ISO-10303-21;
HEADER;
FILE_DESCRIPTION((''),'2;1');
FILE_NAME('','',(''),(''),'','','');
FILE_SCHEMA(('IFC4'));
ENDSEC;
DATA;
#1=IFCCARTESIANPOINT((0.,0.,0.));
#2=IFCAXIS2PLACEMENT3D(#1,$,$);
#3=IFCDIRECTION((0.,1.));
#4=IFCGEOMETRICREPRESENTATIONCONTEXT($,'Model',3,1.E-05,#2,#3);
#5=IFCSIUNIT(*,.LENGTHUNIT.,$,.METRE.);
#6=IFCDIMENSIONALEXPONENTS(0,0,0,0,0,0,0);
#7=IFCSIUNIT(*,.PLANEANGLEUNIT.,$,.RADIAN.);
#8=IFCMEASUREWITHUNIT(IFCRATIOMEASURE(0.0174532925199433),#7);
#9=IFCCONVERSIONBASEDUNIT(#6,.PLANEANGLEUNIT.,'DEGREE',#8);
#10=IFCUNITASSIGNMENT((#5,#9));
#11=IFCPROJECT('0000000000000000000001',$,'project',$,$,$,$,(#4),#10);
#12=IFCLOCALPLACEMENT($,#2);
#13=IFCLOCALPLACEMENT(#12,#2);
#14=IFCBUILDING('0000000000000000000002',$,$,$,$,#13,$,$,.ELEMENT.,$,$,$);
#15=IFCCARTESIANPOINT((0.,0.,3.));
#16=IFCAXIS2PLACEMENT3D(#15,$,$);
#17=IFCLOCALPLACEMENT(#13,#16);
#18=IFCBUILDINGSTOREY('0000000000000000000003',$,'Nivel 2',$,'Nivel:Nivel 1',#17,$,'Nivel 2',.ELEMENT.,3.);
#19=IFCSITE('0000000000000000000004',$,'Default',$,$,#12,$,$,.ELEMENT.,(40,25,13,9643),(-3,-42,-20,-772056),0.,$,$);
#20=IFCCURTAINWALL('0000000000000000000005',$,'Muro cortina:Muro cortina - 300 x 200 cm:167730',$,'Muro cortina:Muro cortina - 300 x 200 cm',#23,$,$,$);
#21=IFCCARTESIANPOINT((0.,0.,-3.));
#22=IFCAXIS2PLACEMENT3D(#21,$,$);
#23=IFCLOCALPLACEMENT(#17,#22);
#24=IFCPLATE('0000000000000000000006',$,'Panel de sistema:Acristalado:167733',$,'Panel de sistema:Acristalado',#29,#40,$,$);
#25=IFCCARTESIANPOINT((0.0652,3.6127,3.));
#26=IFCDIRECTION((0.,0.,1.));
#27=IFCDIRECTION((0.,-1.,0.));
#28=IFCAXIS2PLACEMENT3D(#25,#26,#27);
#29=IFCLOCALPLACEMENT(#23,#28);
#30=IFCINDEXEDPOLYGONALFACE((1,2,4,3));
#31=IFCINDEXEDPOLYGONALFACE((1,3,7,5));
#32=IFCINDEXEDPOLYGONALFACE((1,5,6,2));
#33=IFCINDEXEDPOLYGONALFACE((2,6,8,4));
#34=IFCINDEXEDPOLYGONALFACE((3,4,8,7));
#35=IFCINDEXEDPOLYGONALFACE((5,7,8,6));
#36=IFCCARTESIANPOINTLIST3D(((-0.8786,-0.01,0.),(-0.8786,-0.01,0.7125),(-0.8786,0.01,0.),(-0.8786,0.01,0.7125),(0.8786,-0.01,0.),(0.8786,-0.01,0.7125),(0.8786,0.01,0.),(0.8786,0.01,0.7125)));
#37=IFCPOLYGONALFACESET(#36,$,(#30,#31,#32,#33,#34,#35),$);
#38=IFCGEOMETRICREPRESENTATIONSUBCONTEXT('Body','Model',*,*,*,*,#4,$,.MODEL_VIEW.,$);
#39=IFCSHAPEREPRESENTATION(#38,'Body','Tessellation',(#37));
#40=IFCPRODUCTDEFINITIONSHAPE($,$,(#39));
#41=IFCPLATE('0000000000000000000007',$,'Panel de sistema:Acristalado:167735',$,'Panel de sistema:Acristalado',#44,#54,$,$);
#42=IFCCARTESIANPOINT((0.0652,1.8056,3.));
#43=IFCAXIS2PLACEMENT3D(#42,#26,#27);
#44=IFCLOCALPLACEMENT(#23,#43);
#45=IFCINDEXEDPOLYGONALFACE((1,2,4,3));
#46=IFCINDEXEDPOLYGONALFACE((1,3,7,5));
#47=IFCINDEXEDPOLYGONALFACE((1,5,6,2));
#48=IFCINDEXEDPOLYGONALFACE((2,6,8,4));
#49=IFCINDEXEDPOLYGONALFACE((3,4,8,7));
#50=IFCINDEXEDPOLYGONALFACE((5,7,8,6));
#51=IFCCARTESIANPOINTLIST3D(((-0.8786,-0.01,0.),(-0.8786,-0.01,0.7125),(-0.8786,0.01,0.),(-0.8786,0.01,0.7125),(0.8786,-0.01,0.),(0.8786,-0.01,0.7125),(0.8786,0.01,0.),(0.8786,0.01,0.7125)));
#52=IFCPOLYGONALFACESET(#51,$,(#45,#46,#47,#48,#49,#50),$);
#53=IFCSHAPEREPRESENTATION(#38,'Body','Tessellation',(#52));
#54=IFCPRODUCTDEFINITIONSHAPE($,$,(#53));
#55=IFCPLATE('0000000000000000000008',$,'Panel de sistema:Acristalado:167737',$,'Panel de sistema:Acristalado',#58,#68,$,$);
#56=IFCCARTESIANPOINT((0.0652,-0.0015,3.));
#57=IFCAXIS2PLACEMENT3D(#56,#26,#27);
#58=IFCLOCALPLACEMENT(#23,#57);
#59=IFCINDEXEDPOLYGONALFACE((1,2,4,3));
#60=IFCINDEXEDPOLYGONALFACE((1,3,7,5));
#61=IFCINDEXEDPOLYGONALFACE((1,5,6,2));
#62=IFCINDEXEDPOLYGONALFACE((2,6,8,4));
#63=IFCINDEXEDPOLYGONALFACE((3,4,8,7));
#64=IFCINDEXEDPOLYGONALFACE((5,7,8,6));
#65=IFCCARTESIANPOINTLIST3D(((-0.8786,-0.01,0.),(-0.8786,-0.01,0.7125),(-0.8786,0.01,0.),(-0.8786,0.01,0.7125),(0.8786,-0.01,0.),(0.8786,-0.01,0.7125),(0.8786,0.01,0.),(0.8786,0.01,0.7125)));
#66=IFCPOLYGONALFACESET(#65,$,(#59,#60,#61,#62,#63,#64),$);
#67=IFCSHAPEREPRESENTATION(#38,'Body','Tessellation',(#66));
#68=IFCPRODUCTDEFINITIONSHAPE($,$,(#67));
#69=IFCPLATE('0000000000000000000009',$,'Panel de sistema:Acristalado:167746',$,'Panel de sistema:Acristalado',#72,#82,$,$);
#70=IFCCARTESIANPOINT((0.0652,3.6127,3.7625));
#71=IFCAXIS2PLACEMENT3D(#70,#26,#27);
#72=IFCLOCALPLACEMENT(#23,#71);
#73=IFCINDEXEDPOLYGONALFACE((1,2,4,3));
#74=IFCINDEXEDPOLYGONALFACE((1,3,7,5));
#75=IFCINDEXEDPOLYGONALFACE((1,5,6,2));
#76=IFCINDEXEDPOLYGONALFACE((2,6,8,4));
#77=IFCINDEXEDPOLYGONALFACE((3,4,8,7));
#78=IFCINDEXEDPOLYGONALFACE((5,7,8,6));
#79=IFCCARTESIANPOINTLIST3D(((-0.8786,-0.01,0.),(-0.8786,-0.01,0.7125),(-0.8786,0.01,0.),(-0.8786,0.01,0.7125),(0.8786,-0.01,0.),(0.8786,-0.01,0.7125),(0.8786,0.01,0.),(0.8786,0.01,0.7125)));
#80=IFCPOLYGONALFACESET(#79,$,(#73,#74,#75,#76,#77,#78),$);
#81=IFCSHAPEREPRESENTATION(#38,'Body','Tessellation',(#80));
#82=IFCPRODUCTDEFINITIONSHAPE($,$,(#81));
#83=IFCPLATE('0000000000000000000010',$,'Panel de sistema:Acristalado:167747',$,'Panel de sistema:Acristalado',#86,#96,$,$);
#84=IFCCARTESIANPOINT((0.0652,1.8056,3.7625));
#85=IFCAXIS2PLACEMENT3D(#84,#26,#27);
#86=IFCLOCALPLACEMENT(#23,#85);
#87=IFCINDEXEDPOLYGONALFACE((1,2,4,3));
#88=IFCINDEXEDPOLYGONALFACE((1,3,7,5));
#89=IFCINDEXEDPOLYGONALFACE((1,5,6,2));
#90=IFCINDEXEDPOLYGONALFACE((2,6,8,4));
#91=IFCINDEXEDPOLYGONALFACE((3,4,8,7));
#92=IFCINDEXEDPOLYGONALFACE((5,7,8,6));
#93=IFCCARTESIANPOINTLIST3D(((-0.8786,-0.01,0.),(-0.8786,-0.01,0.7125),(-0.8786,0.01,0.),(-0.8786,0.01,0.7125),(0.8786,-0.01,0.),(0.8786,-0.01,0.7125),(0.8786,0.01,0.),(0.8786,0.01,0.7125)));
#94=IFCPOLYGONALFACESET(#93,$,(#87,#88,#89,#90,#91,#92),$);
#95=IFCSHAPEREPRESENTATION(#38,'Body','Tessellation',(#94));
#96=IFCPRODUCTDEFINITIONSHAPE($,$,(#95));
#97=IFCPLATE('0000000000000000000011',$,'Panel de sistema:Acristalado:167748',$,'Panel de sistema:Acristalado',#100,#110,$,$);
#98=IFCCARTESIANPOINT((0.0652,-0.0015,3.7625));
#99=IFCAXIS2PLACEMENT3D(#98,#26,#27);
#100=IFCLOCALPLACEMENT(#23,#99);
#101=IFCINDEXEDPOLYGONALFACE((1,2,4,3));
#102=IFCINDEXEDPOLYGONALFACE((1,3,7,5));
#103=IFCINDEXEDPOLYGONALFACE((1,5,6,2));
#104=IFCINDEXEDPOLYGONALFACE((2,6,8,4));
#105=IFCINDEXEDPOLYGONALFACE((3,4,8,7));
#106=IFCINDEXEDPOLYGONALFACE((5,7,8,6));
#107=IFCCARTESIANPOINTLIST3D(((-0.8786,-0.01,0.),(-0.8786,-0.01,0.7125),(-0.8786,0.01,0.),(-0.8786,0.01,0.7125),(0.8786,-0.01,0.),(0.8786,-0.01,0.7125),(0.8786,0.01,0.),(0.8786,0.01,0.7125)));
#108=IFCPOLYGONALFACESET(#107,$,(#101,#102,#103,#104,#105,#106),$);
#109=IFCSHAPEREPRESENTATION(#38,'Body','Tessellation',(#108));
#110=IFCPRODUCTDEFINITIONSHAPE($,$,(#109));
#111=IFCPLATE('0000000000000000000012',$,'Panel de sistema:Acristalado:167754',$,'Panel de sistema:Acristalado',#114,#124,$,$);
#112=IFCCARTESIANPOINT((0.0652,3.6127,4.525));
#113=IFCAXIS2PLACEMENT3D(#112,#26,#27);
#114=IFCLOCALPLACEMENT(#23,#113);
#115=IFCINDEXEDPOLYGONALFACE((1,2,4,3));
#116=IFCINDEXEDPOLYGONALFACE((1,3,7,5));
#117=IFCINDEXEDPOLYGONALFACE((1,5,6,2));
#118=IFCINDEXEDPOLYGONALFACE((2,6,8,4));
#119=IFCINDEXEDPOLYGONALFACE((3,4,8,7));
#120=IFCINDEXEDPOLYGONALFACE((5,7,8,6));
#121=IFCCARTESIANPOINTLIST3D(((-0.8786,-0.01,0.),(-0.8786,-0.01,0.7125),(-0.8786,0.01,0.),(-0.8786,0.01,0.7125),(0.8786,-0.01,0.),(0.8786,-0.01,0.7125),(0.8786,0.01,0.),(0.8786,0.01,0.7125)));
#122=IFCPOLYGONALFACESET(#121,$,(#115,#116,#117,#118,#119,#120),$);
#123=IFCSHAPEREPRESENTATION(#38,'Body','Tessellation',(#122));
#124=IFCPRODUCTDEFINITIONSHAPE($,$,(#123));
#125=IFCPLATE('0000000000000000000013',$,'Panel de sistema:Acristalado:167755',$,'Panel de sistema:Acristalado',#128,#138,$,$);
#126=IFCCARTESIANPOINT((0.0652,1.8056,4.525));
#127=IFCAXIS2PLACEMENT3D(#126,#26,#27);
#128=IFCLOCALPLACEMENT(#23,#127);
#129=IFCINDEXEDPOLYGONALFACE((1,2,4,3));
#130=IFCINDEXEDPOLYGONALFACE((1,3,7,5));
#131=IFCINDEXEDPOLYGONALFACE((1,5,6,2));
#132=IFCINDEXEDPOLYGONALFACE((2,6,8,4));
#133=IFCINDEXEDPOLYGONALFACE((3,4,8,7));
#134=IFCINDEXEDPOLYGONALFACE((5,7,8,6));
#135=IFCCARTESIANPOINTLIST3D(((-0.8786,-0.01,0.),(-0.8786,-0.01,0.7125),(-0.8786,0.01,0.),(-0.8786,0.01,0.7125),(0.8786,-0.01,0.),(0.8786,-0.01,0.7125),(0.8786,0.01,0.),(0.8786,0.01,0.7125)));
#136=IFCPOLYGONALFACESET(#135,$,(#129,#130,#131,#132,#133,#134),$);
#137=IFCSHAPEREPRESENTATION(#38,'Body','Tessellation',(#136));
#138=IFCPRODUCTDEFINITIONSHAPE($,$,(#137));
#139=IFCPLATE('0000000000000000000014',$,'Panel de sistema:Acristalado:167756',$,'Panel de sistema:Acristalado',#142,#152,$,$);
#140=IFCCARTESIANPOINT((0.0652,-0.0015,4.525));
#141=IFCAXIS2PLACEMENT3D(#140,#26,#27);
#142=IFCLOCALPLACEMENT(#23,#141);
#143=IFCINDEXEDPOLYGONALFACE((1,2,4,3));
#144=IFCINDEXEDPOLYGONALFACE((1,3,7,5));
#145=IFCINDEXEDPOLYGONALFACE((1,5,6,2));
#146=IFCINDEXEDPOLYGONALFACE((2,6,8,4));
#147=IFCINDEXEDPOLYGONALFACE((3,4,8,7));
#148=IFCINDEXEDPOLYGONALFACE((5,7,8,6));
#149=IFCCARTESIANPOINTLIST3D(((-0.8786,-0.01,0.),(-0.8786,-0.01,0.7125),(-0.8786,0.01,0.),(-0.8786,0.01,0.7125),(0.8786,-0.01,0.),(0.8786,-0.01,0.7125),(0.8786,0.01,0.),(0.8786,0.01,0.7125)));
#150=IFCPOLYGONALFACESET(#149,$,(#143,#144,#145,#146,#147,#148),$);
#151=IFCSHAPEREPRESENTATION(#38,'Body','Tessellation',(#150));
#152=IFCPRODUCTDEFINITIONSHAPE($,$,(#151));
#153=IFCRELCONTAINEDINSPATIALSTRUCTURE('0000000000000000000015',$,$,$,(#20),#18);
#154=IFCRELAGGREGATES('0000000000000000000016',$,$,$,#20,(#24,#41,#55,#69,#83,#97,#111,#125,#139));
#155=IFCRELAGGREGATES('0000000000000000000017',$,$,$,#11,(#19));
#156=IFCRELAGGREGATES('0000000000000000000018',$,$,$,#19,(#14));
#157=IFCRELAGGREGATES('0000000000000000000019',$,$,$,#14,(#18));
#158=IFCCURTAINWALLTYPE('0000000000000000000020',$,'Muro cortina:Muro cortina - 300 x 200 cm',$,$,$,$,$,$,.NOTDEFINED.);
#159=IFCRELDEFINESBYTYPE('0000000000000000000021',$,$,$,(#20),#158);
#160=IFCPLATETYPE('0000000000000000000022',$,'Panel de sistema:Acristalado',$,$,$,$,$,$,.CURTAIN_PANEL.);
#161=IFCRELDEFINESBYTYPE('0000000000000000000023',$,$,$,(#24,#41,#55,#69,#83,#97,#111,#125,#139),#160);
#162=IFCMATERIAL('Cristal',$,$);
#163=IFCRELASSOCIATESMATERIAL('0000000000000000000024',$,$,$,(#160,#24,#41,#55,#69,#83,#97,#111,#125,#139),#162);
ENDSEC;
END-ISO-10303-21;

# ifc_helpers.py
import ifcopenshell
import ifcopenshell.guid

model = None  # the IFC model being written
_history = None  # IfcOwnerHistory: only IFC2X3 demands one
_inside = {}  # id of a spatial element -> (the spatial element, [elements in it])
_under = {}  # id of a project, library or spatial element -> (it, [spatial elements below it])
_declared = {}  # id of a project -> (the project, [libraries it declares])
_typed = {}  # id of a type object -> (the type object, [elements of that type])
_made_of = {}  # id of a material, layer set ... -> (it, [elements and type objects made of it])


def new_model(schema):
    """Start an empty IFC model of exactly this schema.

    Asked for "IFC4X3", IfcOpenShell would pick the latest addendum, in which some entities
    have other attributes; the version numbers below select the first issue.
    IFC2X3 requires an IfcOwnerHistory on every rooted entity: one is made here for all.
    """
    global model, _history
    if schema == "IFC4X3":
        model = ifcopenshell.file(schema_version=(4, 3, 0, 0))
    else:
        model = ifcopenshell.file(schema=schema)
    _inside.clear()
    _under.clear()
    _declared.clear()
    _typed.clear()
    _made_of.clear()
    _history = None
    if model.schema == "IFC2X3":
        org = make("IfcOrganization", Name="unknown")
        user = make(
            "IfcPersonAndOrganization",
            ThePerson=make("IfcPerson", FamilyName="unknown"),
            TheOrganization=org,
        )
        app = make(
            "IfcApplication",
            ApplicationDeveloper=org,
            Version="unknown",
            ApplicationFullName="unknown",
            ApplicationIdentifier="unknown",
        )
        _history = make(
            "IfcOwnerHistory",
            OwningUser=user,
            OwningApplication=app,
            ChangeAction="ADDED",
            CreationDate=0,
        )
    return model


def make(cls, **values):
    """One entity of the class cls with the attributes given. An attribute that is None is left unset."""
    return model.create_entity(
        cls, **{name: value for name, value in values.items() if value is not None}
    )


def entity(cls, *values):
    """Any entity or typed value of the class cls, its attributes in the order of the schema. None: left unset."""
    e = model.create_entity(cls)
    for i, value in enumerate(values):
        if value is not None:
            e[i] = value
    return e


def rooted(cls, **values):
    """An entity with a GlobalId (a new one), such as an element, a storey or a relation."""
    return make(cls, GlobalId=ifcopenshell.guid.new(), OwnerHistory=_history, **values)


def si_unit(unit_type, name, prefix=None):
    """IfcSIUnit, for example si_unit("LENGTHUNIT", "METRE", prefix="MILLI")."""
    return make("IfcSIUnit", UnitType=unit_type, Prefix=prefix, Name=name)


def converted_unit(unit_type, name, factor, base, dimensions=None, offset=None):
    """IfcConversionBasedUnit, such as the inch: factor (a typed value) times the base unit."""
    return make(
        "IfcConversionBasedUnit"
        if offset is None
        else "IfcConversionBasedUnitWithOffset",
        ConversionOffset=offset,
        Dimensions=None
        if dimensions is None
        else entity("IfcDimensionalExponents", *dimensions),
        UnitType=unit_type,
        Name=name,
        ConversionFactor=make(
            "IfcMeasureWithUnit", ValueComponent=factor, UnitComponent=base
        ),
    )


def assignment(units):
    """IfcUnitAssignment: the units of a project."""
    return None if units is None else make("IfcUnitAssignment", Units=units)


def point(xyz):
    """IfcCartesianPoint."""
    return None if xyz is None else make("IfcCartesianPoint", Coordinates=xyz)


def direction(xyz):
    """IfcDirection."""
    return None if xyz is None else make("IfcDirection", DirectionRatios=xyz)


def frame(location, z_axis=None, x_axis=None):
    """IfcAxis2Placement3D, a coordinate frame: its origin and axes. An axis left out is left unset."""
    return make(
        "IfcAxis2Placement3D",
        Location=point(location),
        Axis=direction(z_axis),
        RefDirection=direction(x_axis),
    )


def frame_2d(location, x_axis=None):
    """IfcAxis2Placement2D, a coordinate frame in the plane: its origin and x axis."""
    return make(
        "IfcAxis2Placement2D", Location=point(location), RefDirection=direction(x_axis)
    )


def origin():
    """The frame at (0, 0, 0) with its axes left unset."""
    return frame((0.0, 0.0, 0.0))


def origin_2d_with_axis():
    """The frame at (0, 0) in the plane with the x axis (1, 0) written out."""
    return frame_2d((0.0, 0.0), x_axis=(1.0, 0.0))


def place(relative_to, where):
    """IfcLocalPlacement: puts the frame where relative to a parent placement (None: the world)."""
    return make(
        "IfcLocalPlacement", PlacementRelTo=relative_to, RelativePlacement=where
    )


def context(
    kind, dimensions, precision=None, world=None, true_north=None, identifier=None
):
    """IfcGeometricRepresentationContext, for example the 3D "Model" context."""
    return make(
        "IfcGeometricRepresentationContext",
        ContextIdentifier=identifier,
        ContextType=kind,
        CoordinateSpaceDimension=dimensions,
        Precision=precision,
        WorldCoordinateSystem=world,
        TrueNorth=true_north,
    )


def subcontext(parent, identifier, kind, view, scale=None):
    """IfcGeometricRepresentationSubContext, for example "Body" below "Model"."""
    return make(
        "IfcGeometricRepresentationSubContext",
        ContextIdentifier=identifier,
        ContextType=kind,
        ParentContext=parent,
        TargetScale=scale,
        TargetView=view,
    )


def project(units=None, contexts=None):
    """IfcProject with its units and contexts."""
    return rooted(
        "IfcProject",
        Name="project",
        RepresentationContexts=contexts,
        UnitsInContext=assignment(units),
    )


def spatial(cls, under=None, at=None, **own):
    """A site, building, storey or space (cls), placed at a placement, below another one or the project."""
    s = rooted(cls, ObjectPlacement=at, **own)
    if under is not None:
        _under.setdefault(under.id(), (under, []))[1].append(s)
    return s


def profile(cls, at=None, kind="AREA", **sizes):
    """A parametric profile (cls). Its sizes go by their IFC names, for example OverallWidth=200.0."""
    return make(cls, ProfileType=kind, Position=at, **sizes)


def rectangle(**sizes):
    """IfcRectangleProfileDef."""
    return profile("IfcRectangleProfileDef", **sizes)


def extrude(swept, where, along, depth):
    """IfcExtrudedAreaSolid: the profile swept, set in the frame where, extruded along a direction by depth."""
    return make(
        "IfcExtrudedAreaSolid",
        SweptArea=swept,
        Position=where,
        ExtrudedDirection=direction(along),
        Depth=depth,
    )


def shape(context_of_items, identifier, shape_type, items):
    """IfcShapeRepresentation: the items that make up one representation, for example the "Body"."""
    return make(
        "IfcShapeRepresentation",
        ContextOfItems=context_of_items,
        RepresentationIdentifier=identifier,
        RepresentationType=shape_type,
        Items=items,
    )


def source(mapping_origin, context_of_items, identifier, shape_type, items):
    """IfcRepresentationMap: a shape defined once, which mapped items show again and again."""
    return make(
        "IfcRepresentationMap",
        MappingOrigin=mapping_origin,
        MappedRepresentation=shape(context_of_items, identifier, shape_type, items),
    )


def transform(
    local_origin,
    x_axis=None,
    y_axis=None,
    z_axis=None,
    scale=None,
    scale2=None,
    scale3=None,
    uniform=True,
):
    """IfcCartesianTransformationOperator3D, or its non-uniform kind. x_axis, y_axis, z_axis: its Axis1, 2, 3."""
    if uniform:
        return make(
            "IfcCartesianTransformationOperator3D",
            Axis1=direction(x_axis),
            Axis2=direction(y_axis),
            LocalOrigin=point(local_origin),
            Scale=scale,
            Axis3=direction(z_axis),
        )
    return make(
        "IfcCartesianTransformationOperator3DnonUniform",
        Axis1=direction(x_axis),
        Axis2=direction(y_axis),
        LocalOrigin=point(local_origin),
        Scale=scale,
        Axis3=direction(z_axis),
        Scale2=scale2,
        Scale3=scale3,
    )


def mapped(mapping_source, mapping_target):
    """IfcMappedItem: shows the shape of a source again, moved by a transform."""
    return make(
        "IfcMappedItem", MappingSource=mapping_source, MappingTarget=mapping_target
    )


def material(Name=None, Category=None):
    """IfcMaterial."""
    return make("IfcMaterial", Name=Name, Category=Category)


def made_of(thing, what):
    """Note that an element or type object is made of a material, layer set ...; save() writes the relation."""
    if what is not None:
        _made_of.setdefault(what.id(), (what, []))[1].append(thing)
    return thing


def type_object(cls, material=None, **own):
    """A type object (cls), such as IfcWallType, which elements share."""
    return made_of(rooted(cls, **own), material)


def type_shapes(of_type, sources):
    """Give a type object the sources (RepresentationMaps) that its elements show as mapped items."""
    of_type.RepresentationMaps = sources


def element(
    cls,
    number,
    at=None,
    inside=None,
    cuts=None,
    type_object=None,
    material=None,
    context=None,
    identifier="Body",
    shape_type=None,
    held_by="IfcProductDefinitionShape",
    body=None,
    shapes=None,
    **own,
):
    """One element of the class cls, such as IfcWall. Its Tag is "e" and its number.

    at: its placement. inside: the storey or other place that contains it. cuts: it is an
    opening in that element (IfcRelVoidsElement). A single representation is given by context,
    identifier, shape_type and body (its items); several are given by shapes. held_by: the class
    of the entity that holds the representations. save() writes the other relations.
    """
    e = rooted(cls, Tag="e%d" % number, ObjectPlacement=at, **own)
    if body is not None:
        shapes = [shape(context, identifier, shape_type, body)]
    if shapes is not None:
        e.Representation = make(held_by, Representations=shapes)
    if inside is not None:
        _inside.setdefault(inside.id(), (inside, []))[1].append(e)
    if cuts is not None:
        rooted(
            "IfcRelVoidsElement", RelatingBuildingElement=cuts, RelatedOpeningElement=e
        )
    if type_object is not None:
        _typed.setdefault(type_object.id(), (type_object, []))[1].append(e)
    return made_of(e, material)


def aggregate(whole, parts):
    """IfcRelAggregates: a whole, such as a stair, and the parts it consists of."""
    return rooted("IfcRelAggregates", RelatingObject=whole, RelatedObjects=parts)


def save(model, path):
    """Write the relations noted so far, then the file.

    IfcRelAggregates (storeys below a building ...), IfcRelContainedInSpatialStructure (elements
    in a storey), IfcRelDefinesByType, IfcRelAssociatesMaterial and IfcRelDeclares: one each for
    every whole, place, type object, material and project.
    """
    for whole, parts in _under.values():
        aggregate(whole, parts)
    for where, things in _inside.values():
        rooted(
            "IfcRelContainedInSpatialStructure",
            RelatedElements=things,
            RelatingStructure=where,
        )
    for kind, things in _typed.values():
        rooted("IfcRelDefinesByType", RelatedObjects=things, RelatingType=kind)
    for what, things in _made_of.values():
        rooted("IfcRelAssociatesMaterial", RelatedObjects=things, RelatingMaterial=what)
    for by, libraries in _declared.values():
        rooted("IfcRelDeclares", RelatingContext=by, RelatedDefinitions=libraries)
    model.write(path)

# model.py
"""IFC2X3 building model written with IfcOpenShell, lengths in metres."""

from ifc_helpers import new_model, entity, si_unit, converted_unit, direction, frame, origin, origin_2d_with_axis, place, context, subcontext, project, spatial, rectangle, extrude, source, transform, mapped, material, type_object, type_shapes, element, aggregate, save


model = new_model("IFC2X3")

# Units and contexts
model_context = context("Model", 3, precision=1e-05, world=origin(), true_north=direction((0.0, 1.0)))
body_context = subcontext(model_context, "Body", "Model", "MODEL_VIEW")
ifc_project = project(units=[si_unit("LENGTHUNIT", "METRE"), converted_unit("PLANEANGLEUNIT", "DEGREE", entity("IfcRatioMeasure", 0.0174532925199433), si_unit("PLANEANGLEUNIT", "RADIAN"), dimensions=[0, 0, 0, 0, 0, 0, 0])], contexts=[model_context])

# Site, building, storey
site_placement = place(None, origin())
site = spatial("IfcSite", under=ifc_project, at=site_placement, Name="Default", CompositionType="ELEMENT", RefLatitude=(40, 25, 13, 9643), RefLongitude=(-3, -42, -20, -772056), RefElevation=0.0)
building_placement = place(site_placement, origin())
building = spatial("IfcBuilding", under=site, at=building_placement, CompositionType="ELEMENT")
storey_placement = place(building_placement, frame((0.0, 0.0, 3.0)))
storey = spatial("IfcBuildingStorey", under=building, at=storey_placement, Name="Nivel 2", ObjectType="Nivel:Nivel 1", LongName="Nivel 2", CompositionType="ELEMENT", Elevation=3.0)

# Curtain wall, plates
curtain_wall_type = type_object("IfcCurtainWallType", Name="Muro cortina:Muro cortina - 300 x 200 cm", PredefinedType="NOTDEFINED")
curtain_wall_placement = place(storey_placement, frame((0.0, 0.0, -3.0)))
curtain_wall = element("IfcCurtainWall", 1, at=curtain_wall_placement, inside=storey, type_object=curtain_wall_type, Name="Muro cortina:Muro cortina - 300 x 200 cm:167730", ObjectType="Muro cortina:Muro cortina - 300 x 200 cm")
ifc_material_1 = material(Name="Cristal")
plate_type = type_object("IfcPlateType", Name="Panel de sistema:Acristalado", PredefinedType="CURTAIN_PANEL", material=ifc_material_1)
shared_shape_1 = source(origin(), body_context, "Body", "SweptSolid", [
    extrude(rectangle(XDim=0.02, YDim=1.7571, at=origin_2d_with_axis()), frame((0.0, 0.0, 0.0), z_axis=(0.0, 0.0, 1.0), x_axis=(0.0, 1.0, 0.0)), (0.0, 0.0, 1.0), 0.7125),
])
type_shapes(plate_type, [shared_shape_1])
plate_1_placement = place(curtain_wall_placement, frame((0.0652, 3.6127, 3.0), z_axis=(0.0, 0.0, 1.0), x_axis=(0.0, -1.0, 0.0)))
plate_1 = element("IfcPlate", 2, at=plate_1_placement, type_object=plate_type, material=ifc_material_1, Name="Panel de sistema:Acristalado:167733", ObjectType="Panel de sistema:Acristalado", context=body_context, shape_type="MappedRepresentation", body=[
    mapped(shared_shape_1, transform((0.0, 0.0, 0.0), scale=1.0)),
])
plate_2_placement = place(curtain_wall_placement, frame((0.0652, 1.8056, 3.0), z_axis=(0.0, 0.0, 1.0), x_axis=(0.0, -1.0, 0.0)))
plate_2 = element("IfcPlate", 3, at=plate_2_placement, type_object=plate_type, material=ifc_material_1, Name="Panel de sistema:Acristalado:167735", ObjectType="Panel de sistema:Acristalado", context=body_context, shape_type="MappedRepresentation", body=[
    mapped(shared_shape_1, transform((0.0, 0.0, 0.0), scale=1.0)),
])
plate_3_placement = place(curtain_wall_placement, frame((0.0652, -0.0015, 3.0), z_axis=(0.0, 0.0, 1.0), x_axis=(0.0, -1.0, 0.0)))
plate_3 = element("IfcPlate", 4, at=plate_3_placement, type_object=plate_type, material=ifc_material_1, Name="Panel de sistema:Acristalado:167737", ObjectType="Panel de sistema:Acristalado", context=body_context, shape_type="MappedRepresentation", body=[
    mapped(shared_shape_1, transform((0.0, 0.0, 0.0), scale=1.0)),
])
plate_4_placement = place(curtain_wall_placement, frame((0.0652, 3.6127, 3.7625), z_axis=(0.0, 0.0, 1.0), x_axis=(0.0, -1.0, 0.0)))
plate_4 = element("IfcPlate", 5, at=plate_4_placement, type_object=plate_type, material=ifc_material_1, Name="Panel de sistema:Acristalado:167746", ObjectType="Panel de sistema:Acristalado", context=body_context, shape_type="MappedRepresentation", body=[
    mapped(shared_shape_1, transform((0.0, 0.0, 0.0), scale=1.0)),
])
plate_5_placement = place(curtain_wall_placement, frame((0.0652, 1.8056, 3.7625), z_axis=(0.0, 0.0, 1.0), x_axis=(0.0, -1.0, 0.0)))
plate_5 = element("IfcPlate", 6, at=plate_5_placement, type_object=plate_type, material=ifc_material_1, Name="Panel de sistema:Acristalado:167747", ObjectType="Panel de sistema:Acristalado", context=body_context, shape_type="MappedRepresentation", body=[
    mapped(shared_shape_1, transform((0.0, 0.0, 0.0), scale=1.0)),
])
plate_6_placement = place(curtain_wall_placement, frame((0.0652, -0.0015, 3.7625), z_axis=(0.0, 0.0, 1.0), x_axis=(0.0, -1.0, 0.0)))
plate_6 = element("IfcPlate", 7, at=plate_6_placement, type_object=plate_type, material=ifc_material_1, Name="Panel de sistema:Acristalado:167748", ObjectType="Panel de sistema:Acristalado", context=body_context, shape_type="MappedRepresentation", body=[
    mapped(shared_shape_1, transform((0.0, 0.0, 0.0), scale=1.0)),
])
plate_7_placement = place(curtain_wall_placement, frame((0.0652, 3.6127, 4.525), z_axis=(0.0, 0.0, 1.0), x_axis=(0.0, -1.0, 0.0)))
plate_7 = element("IfcPlate", 8, at=plate_7_placement, type_object=plate_type, material=ifc_material_1, Name="Panel de sistema:Acristalado:167754", ObjectType="Panel de sistema:Acristalado", context=body_context, shape_type="MappedRepresentation", body=[
    mapped(shared_shape_1, transform((0.0, 0.0, 0.0), scale=1.0)),
])
plate_8_placement = place(curtain_wall_placement, frame((0.0652, 1.8056, 4.525), z_axis=(0.0, 0.0, 1.0), x_axis=(0.0, -1.0, 0.0)))
plate_8 = element("IfcPlate", 9, at=plate_8_placement, type_object=plate_type, material=ifc_material_1, Name="Panel de sistema:Acristalado:167755", ObjectType="Panel de sistema:Acristalado", context=body_context, shape_type="MappedRepresentation", body=[
    mapped(shared_shape_1, transform((0.0, 0.0, 0.0), scale=1.0)),
])
plate_9_placement = place(curtain_wall_placement, frame((0.0652, -0.0015, 4.525), z_axis=(0.0, 0.0, 1.0), x_axis=(0.0, -1.0, 0.0)))
plate_9 = element("IfcPlate", 10, at=plate_9_placement, type_object=plate_type, material=ifc_material_1, Name="Panel de sistema:Acristalado:167756", ObjectType="Panel de sistema:Acristalado", context=body_context, shape_type="MappedRepresentation", body=[
    mapped(shared_shape_1, transform((0.0, 0.0, 0.0), scale=1.0)),
])
aggregate(curtain_wall, [plate_1, plate_2, plate_3, plate_4, plate_5, plate_6, plate_7, plate_8, plate_9])

save(model, "model.ifc")
